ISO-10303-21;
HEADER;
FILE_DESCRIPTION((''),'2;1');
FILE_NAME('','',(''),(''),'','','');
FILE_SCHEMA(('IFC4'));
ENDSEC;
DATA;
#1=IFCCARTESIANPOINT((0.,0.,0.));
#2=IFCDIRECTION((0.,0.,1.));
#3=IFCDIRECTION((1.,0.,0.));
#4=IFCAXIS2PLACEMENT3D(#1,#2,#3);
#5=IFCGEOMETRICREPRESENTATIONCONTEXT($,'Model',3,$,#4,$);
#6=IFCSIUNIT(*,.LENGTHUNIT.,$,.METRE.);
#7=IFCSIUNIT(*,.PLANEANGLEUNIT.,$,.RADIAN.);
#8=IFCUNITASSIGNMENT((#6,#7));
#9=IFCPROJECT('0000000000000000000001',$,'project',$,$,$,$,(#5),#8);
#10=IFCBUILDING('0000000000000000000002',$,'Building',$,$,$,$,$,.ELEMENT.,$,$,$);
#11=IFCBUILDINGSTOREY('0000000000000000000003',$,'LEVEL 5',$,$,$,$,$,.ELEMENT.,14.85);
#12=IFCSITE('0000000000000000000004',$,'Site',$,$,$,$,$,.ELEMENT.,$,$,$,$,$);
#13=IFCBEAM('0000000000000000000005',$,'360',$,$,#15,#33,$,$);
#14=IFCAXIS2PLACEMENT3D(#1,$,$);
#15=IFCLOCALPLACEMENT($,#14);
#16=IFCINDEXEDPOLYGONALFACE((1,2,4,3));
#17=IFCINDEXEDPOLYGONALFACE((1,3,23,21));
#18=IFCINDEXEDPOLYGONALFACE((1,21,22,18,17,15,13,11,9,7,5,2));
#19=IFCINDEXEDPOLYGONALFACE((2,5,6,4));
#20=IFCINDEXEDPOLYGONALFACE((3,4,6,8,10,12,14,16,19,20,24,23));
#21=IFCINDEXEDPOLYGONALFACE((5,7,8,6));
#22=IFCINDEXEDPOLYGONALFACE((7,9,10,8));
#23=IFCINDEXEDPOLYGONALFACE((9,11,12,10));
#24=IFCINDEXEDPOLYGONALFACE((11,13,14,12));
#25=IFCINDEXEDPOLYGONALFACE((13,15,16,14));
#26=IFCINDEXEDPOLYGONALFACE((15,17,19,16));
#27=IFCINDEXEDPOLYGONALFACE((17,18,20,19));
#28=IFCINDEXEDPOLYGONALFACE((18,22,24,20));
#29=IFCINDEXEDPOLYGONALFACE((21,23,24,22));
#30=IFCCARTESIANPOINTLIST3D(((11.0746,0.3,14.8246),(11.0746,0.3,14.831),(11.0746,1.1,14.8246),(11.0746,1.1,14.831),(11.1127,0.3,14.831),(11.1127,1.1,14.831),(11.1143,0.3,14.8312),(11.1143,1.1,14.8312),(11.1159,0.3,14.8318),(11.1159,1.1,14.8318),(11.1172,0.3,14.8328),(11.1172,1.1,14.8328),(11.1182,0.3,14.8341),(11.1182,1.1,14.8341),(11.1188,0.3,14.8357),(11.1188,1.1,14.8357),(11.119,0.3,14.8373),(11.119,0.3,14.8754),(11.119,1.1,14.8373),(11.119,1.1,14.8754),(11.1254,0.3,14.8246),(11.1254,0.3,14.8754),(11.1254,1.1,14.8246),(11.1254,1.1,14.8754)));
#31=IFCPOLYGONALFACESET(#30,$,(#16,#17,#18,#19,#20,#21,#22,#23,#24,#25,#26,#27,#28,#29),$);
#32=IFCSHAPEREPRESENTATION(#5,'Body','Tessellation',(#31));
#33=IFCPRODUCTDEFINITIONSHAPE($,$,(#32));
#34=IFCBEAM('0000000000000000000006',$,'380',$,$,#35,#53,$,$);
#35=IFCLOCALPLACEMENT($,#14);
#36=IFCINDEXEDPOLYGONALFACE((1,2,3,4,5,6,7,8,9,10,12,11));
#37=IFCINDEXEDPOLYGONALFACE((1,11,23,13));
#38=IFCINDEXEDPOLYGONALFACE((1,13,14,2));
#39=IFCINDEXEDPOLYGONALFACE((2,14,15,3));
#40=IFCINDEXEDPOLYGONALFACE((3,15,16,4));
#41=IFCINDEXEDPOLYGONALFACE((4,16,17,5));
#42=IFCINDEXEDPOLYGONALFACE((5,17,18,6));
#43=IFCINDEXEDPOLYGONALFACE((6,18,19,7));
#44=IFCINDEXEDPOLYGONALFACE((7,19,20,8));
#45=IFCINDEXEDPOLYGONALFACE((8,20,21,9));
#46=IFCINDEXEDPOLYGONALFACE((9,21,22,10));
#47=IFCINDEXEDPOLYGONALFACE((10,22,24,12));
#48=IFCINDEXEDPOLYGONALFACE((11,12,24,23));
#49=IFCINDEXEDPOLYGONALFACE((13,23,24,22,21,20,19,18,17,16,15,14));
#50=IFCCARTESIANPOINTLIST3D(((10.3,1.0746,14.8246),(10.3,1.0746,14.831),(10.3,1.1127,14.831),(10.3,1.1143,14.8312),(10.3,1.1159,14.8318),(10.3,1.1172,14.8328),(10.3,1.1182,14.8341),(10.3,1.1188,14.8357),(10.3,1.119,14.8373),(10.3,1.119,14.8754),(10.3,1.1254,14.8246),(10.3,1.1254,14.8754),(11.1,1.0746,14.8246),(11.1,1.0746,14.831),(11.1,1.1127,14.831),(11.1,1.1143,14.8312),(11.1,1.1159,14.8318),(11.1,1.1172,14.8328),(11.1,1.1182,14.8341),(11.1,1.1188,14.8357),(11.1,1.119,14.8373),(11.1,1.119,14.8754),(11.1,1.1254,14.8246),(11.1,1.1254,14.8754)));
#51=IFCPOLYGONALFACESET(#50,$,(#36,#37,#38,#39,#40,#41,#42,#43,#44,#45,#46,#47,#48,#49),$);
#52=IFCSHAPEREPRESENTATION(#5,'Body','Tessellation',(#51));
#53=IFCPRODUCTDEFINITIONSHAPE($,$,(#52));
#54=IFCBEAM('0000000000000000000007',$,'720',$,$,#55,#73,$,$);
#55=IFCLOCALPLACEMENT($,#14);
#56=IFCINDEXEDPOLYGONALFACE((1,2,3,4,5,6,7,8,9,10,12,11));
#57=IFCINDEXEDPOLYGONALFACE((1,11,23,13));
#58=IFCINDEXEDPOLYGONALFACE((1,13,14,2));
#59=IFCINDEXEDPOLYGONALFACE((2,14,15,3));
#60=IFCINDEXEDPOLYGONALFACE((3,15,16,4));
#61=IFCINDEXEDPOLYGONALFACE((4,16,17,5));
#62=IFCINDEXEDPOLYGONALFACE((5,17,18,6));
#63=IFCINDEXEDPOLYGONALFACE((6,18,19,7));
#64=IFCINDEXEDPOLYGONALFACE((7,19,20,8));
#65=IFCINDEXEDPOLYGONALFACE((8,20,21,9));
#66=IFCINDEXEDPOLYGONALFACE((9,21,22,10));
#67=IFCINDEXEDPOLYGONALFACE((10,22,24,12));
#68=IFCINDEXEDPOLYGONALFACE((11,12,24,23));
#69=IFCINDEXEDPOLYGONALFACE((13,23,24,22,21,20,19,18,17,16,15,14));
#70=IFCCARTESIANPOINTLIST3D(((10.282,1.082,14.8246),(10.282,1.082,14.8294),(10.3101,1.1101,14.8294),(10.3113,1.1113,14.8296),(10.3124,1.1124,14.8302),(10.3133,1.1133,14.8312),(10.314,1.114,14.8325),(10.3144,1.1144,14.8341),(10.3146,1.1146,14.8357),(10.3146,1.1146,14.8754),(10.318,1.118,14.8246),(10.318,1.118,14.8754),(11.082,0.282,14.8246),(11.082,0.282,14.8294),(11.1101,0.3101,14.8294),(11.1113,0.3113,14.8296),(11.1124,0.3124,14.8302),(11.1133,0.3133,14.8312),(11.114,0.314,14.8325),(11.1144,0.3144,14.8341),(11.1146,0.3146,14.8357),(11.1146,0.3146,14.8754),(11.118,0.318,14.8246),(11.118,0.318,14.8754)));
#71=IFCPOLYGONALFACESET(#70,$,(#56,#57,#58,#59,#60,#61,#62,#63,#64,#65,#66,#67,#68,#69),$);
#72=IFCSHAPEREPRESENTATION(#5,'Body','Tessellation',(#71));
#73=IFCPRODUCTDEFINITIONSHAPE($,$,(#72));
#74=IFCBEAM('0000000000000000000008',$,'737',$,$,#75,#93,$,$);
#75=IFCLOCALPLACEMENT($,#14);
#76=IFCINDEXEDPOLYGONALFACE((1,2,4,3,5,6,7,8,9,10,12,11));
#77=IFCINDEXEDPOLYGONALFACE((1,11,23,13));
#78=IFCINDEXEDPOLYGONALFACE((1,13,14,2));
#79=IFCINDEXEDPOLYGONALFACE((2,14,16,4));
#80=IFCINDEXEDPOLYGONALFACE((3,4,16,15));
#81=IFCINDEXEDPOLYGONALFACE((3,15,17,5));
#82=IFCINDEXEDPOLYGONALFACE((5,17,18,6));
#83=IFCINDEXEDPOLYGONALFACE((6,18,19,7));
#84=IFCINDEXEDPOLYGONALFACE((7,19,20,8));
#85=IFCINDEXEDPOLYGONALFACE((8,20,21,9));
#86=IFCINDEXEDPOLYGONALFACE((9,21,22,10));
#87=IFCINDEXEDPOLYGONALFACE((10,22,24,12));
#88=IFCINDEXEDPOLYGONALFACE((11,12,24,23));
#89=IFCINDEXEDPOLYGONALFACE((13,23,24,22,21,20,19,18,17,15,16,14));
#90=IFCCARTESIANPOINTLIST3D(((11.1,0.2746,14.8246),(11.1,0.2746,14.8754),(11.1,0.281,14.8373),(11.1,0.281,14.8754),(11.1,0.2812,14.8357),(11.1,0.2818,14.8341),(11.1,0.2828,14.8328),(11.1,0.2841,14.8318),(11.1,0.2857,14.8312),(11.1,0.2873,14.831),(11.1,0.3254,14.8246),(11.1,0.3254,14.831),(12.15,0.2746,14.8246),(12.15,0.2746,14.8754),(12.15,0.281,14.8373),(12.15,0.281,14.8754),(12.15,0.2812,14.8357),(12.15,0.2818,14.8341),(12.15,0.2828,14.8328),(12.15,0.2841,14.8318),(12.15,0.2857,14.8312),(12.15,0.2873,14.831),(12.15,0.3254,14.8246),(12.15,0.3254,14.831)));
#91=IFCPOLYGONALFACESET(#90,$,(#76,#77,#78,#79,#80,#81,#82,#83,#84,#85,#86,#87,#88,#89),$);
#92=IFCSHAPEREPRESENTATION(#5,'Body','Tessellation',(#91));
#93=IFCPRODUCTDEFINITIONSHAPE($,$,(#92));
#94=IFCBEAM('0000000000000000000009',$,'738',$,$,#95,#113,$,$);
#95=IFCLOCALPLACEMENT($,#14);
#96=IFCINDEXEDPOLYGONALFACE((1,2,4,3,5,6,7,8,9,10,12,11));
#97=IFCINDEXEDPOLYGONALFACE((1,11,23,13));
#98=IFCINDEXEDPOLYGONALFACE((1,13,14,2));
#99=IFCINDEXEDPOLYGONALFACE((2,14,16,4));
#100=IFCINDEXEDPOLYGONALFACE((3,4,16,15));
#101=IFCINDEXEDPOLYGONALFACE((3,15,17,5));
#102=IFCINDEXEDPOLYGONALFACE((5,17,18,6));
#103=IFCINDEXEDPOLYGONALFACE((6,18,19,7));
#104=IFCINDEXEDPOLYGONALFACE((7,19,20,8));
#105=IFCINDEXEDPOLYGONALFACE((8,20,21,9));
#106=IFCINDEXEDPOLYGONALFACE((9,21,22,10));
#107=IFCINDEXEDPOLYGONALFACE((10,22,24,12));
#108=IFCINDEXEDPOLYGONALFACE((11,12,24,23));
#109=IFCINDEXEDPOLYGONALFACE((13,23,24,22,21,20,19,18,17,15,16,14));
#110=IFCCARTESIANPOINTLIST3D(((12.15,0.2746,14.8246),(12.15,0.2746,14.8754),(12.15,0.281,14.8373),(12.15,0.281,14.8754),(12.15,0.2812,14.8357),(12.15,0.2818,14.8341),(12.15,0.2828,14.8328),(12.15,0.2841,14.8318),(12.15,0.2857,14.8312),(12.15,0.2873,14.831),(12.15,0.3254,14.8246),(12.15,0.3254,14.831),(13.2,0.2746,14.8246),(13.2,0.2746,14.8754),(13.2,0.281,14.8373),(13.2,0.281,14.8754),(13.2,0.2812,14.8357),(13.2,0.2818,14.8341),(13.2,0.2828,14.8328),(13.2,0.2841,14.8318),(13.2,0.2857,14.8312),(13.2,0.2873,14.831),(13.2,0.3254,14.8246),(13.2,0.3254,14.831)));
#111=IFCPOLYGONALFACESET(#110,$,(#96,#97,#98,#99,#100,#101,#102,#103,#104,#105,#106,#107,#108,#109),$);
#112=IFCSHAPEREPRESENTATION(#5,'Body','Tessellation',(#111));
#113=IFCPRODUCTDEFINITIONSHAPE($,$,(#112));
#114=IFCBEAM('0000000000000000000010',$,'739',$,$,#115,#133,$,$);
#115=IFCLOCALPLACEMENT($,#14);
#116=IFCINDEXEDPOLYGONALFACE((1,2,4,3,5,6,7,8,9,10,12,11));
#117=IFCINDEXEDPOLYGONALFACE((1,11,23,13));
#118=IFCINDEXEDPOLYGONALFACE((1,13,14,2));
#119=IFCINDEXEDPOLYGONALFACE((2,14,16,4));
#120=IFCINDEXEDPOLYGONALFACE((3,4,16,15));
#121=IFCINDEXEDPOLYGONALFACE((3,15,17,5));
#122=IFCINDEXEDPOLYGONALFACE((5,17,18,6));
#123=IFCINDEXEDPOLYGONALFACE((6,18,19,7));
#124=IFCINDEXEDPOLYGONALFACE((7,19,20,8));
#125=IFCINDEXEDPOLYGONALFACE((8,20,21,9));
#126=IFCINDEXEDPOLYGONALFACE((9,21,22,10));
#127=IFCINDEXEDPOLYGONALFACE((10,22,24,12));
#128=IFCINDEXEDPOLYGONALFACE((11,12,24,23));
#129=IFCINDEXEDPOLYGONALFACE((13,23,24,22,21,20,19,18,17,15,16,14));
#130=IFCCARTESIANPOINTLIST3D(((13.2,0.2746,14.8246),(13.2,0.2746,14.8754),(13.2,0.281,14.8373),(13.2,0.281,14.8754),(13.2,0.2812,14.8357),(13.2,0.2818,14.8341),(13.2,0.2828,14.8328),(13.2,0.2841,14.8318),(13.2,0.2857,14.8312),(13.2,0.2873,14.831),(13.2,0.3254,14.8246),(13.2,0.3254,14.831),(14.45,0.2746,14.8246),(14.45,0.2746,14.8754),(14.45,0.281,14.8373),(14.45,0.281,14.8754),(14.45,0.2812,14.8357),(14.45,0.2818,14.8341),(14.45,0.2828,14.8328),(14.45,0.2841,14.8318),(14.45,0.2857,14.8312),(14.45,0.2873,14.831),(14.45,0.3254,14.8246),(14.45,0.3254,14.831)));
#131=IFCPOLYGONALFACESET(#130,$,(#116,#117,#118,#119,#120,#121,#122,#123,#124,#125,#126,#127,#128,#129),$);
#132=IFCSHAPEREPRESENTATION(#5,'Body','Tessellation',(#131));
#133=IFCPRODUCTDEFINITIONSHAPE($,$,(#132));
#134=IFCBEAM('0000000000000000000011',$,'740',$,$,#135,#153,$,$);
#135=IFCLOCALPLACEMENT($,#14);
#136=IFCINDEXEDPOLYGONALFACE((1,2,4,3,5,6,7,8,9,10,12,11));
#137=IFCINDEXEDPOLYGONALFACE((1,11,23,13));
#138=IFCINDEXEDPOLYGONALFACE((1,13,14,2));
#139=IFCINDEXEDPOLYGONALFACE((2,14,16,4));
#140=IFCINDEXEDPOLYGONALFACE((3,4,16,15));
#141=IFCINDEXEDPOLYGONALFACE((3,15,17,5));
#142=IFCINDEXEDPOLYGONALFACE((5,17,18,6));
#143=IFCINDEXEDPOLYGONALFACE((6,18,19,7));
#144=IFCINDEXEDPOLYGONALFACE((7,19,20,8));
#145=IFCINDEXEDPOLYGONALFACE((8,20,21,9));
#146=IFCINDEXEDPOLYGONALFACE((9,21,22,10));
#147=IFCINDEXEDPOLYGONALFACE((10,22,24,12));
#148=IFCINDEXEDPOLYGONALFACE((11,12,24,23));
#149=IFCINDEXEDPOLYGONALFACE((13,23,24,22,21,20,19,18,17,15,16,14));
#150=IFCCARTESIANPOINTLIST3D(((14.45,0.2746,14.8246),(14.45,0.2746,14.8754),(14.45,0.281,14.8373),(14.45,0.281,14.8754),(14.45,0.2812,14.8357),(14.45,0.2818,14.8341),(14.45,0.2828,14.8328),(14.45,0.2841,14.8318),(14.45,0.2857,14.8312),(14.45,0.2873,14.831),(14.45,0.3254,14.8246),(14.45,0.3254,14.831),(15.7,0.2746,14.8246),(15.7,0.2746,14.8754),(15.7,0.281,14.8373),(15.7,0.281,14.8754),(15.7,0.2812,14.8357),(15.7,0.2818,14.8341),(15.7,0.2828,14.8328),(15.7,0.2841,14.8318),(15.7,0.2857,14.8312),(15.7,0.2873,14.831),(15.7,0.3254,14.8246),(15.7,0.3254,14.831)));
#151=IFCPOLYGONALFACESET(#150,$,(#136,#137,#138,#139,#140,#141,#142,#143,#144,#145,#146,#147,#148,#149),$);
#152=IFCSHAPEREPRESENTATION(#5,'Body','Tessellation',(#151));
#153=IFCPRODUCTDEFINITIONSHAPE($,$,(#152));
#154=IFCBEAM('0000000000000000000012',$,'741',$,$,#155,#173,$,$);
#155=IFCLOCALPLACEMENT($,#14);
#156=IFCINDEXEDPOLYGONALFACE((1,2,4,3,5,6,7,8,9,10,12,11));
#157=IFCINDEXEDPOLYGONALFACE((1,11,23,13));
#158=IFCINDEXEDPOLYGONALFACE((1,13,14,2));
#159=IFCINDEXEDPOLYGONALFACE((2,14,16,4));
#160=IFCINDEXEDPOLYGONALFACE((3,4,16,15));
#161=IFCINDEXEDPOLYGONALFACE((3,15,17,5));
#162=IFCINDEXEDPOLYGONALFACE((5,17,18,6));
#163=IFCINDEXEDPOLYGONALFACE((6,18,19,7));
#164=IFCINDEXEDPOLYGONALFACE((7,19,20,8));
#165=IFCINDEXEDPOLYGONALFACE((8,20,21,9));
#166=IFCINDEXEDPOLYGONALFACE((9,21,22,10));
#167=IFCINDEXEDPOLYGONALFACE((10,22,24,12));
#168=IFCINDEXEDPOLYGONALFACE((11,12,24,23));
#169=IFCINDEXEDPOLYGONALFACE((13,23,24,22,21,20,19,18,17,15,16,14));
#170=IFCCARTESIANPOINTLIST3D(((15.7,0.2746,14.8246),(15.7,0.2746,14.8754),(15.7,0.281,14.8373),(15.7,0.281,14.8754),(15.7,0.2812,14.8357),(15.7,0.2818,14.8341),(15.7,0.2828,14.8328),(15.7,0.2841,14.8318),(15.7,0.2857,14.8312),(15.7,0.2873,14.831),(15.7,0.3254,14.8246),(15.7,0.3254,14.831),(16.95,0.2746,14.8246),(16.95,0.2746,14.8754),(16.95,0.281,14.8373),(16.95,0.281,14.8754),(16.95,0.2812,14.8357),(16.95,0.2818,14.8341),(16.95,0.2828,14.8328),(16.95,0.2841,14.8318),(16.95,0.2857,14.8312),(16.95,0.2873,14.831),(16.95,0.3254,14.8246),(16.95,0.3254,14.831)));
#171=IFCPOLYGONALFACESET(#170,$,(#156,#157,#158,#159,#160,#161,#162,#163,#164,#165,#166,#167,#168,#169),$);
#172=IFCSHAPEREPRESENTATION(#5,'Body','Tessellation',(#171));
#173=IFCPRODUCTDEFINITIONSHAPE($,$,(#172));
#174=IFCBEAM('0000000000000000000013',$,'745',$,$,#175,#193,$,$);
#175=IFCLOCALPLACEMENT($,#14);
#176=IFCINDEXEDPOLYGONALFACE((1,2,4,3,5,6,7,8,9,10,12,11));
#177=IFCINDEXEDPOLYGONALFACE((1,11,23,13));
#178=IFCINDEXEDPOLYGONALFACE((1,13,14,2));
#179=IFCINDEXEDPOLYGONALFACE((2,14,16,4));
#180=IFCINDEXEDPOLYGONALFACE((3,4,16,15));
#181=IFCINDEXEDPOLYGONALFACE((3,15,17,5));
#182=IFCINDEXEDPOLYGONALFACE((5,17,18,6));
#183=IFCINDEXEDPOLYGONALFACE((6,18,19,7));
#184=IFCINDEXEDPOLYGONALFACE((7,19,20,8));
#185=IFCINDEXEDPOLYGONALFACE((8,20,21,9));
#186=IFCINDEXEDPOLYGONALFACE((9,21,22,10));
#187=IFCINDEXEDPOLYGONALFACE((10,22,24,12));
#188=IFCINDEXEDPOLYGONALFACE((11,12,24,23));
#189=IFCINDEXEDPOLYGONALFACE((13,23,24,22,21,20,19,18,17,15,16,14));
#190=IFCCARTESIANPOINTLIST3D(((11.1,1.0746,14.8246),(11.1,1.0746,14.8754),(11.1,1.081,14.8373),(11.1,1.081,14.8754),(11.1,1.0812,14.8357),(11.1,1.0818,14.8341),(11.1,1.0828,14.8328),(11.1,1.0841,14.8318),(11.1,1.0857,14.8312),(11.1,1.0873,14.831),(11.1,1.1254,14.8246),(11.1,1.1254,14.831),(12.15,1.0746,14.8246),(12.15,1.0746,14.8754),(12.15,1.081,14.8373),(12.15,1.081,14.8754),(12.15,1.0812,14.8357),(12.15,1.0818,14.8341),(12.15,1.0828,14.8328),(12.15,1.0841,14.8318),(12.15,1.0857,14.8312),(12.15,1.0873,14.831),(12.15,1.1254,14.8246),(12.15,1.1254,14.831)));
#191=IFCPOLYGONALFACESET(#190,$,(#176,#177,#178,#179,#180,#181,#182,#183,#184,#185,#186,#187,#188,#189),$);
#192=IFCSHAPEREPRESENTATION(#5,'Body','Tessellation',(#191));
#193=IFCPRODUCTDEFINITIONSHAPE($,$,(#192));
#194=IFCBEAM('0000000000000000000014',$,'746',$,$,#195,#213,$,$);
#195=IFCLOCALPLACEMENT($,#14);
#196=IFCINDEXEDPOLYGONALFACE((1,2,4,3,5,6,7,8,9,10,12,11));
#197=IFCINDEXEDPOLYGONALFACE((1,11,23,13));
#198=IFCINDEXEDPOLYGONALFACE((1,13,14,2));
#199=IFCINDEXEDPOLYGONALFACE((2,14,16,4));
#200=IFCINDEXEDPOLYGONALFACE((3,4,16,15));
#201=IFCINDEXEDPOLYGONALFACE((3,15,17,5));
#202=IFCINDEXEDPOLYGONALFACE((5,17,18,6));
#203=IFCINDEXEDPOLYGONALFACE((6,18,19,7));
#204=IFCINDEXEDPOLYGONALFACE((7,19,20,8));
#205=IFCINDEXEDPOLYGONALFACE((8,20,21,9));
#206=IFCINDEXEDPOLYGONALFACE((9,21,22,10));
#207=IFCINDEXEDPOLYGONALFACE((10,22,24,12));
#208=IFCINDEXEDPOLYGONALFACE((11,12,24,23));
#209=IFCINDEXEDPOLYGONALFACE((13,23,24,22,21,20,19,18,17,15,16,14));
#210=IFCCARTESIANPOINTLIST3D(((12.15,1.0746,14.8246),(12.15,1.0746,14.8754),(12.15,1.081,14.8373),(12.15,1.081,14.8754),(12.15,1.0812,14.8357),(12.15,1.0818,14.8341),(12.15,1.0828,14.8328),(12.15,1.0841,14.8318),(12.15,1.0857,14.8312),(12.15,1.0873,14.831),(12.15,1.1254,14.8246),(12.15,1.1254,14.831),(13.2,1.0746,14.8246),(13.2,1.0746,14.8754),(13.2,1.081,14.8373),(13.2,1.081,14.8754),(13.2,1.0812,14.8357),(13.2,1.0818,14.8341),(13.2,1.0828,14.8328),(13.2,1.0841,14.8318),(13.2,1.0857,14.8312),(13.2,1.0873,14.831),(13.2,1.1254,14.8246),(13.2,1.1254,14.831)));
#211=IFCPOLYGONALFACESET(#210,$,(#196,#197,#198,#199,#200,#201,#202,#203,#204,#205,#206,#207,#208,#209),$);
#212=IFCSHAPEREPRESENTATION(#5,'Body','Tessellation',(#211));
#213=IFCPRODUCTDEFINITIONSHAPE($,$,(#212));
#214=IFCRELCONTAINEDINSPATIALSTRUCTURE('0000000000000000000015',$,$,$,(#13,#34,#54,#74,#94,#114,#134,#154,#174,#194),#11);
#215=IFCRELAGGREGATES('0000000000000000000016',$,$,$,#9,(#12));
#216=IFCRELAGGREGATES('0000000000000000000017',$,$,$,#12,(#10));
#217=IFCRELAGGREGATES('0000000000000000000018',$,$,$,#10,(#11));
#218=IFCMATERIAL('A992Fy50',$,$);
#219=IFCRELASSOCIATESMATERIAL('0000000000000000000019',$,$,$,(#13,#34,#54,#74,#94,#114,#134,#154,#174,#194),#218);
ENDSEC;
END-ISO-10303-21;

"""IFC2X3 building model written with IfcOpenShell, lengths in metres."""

from ifc_helpers import new_model, si_unit, frame, origin_with_axes, origin_2d_with_axis, place, context, project, spatial, l_section, extrude, material, element, save


model = new_model("IFC2X3")

# Units and contexts
model_context = context("Model", 3, world=origin_with_axes())
ifc_project = project(units=[si_unit("LENGTHUNIT", "METRE"), si_unit("PLANEANGLEUNIT", "RADIAN")], contexts=[model_context])

# Site, building, storey
site = spatial("IfcSite", under=ifc_project, Name="Site", CompositionType="ELEMENT")
building = spatial("IfcBuilding", under=site, Name="Building", CompositionType="ELEMENT")
storey = spatial("IfcBuildingStorey", under=building, Name="LEVEL 5", CompositionType="ELEMENT", Elevation=14.85)

# Beams
ifc_material = material(Name="A992Fy50")
for number, where, z_axis, x_axis, name in (
    (1, (11.1, 0.3, 14.85), (0.0, 1.0, 0.0), (-1.0, 0.0, 0.0), "360"),
    (2, (11.1, 1.1, 14.85), (-1.0, 0.0, 0.0), (0.0, -1.0, 0.0), "380"),
):
    element("IfcBeam", number, at=place(None, frame(where, z_axis=z_axis, x_axis=x_axis)), inside=storey, material=ifc_material, Name=name, context=model_context, shape_type="SweptSolid", body=[
        extrude(l_section(Depth=0.0508, Width=0.0508, Thickness=0.0063, FilletRadius=0.0063, at=origin_2d_with_axis()), origin_with_axes(), (0.0, 0.0, 1.0), 0.8),
    ])
beam_1_placement = place(None, frame((11.1, 0.3, 14.85), z_axis=(-0.707107, 0.707107, 0.0), x_axis=(-0.707107, -0.707107, 0.0)))
element("IfcBeam", 3, at=beam_1_placement, inside=storey, material=ifc_material, Name="720", context=model_context, shape_type="SweptSolid", body=[
    extrude(l_section(Depth=0.0508, Width=0.0508, Thickness=0.0048, FilletRadius=0.0063, at=origin_2d_with_axis()), origin_with_axes(), (0.0, 0.0, 1.0), 1.1314),
])
for number, where, z_axis, x_axis, name in (
    (4, (11.1, 0.3, 14.85), (1.0, 0.0, 0.0), (0.0, 1.0, 0.0), "737"),
    (5, (12.15, 0.3, 14.85), (1.0, 0.0, 0.0), (0.0, 1.0, 0.0), "738"),
):
    element("IfcBeam", number, at=place(None, frame(where, z_axis=z_axis, x_axis=x_axis)), inside=storey, material=ifc_material, Name=name, context=model_context, shape_type="SweptSolid", body=[
        extrude(l_section(Depth=0.0508, Width=0.0508, Thickness=0.0063, FilletRadius=0.0063, at=origin_2d_with_axis()), origin_with_axes(), (0.0, 0.0, 1.0), 1.05),
    ])
for number, where, z_axis, x_axis, name in (
    (6, (13.2, 0.3, 14.85), (1.0, 0.0, 0.0), (0.0, 1.0, 0.0), "739"),
    (7, (14.45, 0.3, 14.85), (1.0, 0.0, 0.0), (0.0, 1.0, 0.0), "740"),
    (8, (15.7, 0.3, 14.85), (1.0, 0.0, 0.0), (0.0, 1.0, 0.0), "741"),
):
    element("IfcBeam", number, at=place(None, frame(where, z_axis=z_axis, x_axis=x_axis)), inside=storey, material=ifc_material, Name=name, context=model_context, shape_type="SweptSolid", body=[
        extrude(l_section(Depth=0.0508, Width=0.0508, Thickness=0.0063, FilletRadius=0.0063, at=origin_2d_with_axis()), origin_with_axes(), (0.0, 0.0, 1.0), 1.25),
    ])
for number, where, z_axis, x_axis, name in (
    (9, (11.1, 1.1, 14.85), (1.0, 0.0, 0.0), (0.0, 1.0, 0.0), "745"),
    (10, (12.15, 1.1, 14.85), (1.0, 0.0, 0.0), (0.0, 1.0, 0.0), "746"),
):
    element("IfcBeam", number, at=place(None, frame(where, z_axis=z_axis, x_axis=x_axis)), inside=storey, material=ifc_material, Name=name, context=model_context, shape_type="SweptSolid", body=[
        extrude(l_section(Depth=0.0508, Width=0.0508, Thickness=0.0063, FilletRadius=0.0063, at=origin_2d_with_axis()), origin_with_axes(), (0.0, 0.0, 1.0), 1.05),
    ])

save(model, "model.ifc")
